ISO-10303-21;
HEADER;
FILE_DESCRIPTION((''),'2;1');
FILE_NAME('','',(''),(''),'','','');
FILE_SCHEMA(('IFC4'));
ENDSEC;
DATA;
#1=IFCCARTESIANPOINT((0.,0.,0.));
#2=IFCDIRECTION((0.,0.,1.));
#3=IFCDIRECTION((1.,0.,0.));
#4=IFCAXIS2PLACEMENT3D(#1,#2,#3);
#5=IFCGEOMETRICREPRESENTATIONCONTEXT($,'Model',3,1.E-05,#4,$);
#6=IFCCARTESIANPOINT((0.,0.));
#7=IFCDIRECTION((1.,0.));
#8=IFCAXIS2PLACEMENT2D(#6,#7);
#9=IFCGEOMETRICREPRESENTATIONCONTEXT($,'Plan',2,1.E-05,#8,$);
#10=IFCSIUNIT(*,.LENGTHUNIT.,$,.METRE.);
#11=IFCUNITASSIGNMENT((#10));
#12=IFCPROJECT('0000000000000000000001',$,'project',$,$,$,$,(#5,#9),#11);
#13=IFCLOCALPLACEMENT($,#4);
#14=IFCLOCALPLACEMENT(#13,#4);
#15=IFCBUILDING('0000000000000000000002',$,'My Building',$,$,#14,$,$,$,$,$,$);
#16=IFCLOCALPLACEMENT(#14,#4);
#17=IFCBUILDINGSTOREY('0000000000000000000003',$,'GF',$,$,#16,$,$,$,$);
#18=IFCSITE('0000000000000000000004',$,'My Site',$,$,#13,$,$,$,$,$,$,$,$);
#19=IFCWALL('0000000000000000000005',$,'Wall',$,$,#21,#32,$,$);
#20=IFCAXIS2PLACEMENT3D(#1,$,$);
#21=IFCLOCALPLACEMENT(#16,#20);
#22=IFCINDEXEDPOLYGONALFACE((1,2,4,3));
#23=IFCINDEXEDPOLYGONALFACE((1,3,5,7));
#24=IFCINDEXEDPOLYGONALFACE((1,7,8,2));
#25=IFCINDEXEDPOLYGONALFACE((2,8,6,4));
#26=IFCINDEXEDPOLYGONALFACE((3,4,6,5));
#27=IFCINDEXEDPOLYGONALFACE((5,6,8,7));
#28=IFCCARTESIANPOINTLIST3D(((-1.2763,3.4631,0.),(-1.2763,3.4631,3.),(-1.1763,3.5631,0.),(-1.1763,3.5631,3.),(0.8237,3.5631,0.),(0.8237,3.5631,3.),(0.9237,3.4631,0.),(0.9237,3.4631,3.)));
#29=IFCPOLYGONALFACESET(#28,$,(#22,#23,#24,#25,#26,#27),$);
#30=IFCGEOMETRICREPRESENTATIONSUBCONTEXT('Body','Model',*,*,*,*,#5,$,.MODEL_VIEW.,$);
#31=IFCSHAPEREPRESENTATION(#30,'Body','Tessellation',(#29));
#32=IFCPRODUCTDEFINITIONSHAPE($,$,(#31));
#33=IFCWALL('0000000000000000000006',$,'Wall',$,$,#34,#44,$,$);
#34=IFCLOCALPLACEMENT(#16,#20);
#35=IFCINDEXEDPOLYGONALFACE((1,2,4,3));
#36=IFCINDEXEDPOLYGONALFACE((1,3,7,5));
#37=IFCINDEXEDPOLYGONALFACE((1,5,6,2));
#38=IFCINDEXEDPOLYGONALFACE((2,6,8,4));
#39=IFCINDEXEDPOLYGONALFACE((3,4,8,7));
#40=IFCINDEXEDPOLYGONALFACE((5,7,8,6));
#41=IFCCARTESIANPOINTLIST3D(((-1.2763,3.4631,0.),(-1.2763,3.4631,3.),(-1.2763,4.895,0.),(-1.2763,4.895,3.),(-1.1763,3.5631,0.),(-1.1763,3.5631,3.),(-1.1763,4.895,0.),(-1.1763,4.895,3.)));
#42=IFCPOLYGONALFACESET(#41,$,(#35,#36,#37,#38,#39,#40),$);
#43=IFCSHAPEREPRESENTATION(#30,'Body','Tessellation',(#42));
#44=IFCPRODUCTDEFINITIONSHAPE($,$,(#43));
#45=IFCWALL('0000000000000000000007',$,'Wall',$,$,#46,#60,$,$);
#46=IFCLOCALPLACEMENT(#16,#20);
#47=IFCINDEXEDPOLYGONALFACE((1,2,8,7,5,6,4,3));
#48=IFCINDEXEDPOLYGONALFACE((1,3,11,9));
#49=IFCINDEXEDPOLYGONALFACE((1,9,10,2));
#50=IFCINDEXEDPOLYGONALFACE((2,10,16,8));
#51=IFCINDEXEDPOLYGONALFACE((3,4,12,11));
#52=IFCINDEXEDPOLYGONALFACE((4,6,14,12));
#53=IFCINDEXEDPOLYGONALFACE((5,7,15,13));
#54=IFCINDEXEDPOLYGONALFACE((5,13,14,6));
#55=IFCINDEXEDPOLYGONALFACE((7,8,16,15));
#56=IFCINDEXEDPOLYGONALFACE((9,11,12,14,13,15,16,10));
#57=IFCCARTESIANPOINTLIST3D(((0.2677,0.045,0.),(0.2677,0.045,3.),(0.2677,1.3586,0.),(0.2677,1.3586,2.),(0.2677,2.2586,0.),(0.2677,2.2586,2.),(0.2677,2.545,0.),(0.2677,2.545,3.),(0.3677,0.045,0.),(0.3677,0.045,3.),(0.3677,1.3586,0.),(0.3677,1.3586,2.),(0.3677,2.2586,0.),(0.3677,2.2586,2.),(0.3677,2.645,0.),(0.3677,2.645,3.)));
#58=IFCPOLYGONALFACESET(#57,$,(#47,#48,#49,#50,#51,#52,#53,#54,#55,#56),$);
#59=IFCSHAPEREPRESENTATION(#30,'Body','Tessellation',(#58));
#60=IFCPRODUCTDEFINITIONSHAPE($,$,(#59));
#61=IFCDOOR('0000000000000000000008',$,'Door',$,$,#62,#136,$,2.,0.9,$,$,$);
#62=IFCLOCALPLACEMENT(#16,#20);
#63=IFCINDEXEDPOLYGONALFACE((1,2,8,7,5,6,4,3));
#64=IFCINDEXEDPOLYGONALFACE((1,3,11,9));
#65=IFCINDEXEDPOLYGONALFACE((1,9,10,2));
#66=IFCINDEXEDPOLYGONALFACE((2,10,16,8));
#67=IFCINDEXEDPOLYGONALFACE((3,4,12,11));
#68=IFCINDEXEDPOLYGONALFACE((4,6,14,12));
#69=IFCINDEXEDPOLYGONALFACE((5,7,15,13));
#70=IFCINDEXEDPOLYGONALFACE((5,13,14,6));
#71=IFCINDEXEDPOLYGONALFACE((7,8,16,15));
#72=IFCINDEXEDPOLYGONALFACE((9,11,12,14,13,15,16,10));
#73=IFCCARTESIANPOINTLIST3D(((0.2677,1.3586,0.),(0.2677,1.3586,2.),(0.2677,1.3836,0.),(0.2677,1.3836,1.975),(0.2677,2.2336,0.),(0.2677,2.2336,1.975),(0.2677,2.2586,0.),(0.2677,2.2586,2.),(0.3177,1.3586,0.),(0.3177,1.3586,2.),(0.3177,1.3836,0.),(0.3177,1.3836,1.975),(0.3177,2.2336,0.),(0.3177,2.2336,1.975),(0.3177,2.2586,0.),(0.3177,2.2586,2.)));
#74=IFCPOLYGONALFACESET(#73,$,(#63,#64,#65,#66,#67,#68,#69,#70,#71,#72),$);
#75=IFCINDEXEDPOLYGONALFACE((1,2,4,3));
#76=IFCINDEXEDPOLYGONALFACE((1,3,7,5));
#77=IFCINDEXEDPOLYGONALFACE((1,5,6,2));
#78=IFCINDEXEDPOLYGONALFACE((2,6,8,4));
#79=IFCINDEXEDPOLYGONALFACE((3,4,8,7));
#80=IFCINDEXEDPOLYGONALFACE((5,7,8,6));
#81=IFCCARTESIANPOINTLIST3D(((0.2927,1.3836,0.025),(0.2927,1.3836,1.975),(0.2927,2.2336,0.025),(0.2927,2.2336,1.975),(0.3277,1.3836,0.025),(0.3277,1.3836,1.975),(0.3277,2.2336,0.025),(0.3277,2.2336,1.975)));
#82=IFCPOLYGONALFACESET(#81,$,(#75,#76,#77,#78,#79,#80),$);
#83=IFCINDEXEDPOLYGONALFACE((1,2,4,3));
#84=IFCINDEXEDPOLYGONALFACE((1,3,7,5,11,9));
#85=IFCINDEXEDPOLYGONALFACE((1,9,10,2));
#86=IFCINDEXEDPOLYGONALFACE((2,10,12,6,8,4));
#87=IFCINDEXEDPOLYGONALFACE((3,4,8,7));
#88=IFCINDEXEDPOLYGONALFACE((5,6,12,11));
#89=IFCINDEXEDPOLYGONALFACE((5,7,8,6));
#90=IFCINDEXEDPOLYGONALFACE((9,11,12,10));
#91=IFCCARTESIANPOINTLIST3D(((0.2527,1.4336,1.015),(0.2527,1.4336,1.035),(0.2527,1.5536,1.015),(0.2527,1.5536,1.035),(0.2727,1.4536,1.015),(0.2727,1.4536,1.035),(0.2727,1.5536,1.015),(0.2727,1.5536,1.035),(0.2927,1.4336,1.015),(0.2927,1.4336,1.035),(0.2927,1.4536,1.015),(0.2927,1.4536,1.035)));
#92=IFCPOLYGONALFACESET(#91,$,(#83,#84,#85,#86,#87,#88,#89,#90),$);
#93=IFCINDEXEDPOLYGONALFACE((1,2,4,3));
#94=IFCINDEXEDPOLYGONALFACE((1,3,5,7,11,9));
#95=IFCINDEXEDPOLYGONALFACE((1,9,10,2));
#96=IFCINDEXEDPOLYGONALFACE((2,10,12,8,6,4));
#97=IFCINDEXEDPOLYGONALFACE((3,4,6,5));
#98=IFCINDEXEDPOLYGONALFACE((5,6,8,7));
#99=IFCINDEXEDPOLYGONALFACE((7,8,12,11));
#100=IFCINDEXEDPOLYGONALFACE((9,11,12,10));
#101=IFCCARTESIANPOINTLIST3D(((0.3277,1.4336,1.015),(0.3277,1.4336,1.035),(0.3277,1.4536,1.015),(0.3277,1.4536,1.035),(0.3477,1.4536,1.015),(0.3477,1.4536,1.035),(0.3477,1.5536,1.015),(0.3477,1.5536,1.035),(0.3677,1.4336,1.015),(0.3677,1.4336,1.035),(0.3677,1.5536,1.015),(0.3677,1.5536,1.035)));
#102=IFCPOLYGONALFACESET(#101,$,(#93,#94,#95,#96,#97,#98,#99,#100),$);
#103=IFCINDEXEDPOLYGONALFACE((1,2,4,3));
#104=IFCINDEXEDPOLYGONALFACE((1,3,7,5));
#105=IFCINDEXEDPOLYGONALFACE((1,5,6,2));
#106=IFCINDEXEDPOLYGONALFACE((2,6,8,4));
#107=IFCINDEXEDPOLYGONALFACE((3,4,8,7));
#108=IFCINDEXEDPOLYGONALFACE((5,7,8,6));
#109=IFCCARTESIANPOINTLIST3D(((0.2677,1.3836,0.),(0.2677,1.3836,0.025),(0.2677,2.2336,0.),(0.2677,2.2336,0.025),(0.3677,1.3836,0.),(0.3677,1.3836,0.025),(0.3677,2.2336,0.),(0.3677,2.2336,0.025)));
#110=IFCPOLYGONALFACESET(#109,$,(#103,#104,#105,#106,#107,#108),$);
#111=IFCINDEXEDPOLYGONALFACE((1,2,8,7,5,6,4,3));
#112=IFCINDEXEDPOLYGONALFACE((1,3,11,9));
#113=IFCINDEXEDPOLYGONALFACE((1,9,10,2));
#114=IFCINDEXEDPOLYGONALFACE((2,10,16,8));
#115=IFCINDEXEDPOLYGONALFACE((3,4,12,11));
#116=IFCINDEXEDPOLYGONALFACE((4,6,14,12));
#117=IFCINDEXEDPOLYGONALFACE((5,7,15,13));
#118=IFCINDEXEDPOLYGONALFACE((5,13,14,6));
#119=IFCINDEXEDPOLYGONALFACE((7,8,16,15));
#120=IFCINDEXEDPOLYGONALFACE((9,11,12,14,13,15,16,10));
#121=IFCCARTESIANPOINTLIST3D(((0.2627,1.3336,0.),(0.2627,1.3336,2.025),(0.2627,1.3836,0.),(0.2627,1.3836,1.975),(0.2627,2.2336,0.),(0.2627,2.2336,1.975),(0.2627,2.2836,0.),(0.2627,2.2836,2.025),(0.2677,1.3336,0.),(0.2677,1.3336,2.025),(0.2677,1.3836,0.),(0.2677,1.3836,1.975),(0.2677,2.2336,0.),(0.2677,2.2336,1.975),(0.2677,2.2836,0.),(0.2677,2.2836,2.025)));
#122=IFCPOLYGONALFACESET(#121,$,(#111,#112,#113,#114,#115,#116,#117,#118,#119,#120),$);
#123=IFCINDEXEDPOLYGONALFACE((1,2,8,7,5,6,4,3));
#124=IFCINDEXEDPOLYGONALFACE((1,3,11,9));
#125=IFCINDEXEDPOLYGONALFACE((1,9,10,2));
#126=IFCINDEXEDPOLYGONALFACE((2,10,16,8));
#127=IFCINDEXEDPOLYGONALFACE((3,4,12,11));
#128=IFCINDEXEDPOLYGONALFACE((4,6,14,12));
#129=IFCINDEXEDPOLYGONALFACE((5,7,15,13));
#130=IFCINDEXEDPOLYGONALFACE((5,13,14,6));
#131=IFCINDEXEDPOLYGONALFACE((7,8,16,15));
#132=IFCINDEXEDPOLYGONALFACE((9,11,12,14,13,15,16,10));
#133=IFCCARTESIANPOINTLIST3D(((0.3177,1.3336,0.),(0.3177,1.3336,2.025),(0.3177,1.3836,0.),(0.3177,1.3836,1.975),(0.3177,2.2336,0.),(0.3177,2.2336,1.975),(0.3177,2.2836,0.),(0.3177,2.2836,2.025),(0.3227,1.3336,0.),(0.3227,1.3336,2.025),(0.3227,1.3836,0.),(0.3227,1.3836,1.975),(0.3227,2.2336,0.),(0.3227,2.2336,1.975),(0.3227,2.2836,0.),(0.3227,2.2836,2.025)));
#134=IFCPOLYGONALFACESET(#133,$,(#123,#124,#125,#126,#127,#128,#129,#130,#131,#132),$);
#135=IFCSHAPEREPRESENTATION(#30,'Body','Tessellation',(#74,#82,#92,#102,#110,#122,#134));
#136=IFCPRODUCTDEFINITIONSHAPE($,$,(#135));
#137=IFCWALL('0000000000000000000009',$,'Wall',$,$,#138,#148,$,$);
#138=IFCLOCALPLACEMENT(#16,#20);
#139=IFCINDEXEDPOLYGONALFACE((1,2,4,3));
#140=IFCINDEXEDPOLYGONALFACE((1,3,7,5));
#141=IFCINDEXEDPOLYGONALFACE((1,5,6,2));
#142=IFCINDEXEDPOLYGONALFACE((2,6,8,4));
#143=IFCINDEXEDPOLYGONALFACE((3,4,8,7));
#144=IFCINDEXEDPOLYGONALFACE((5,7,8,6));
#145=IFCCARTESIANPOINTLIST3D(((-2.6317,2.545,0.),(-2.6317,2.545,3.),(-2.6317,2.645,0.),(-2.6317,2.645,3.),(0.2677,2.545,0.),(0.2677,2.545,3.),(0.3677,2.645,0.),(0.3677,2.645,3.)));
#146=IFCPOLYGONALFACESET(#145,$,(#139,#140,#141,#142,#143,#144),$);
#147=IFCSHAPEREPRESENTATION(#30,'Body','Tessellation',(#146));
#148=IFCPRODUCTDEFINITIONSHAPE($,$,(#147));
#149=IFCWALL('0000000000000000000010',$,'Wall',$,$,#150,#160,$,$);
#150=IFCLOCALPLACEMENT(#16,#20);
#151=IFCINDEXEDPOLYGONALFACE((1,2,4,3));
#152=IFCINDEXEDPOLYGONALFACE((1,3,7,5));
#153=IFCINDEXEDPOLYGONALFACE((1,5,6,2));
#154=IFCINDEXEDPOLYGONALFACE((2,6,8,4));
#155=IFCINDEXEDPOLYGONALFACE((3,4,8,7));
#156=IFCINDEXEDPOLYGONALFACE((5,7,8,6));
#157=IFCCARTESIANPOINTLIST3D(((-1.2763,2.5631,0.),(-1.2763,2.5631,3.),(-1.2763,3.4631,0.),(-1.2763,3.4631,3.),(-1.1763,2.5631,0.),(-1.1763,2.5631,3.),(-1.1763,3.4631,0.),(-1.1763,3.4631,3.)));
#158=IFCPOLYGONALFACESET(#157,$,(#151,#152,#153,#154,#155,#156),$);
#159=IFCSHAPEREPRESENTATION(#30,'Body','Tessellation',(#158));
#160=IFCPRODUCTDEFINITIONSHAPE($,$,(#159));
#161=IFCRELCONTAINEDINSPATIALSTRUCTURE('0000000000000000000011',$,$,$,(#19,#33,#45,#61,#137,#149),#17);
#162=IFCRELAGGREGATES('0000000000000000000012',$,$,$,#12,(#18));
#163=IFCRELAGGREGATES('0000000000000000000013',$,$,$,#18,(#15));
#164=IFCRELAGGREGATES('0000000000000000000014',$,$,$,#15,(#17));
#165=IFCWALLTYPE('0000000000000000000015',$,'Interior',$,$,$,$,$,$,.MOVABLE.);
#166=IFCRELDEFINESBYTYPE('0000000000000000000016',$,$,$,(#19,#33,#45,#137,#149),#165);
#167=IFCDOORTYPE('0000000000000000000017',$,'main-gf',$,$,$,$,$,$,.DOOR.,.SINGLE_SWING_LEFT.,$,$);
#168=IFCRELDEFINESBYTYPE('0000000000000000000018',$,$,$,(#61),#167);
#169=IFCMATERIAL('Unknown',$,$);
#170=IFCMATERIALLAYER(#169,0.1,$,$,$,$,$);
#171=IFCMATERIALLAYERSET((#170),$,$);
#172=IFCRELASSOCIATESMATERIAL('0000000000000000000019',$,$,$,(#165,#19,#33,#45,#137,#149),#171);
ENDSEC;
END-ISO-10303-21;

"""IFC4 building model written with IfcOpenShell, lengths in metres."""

from ifc_helpers import new_model, entity, si_unit, frame, origin_with_axes, origin_2d_with_axis, place, context, subcontext, project, spatial, line, indexed_curve, outline, extrude, shape, source, transform, mapped, material, layer, layer_set, layer_usage, type_object, type_shapes, element, fill, save


model = new_model("IFC4")

# Units and contexts
model_context = context("Model", 3, precision=1e-05, world=origin_with_axes())
plan_context = context("Plan", 2, precision=1e-05, world=origin_2d_with_axis())
body_context_1 = subcontext(model_context, "Body", "Model", "MODEL_VIEW")
body_context_2 = subcontext(plan_context, "Body", "Plan", "PLAN_VIEW")
ifc_project = project(units=[si_unit("LENGTHUNIT", "METRE")], contexts=[model_context, plan_context])

# Site, building, storey
site_placement = place(None, origin_with_axes())
site = spatial("IfcSite", under=ifc_project, at=site_placement, Name="My Site")
building_placement = place(site_placement, origin_with_axes())
building = spatial("IfcBuilding", under=site, at=building_placement, Name="My Building")
storey_placement = place(building_placement, origin_with_axes())
storey = spatial("IfcBuildingStorey", under=building, at=storey_placement, Name="GF")

# Shared definitions
ifc_material = material(Name="Unknown")
shared_shape_1 = source(origin_with_axes(), body_context_1, "Body", "SweptSolid", [
    extrude(outline(indexed_curve([(0.0, 0.0), (0.9, 0.0), (0.9, 2.0), (0.0, 2.0)], segments=[line(1, 2, 3, 4, 1)])), frame((0.0, -0.6, 0.0), z_axis=(0.0, -1.0, 0.0), x_axis=(1.0, 0.0, 0.0)), (0.0, 0.0, -1.0), 1.2),
])
door_type = type_object("IfcDoorType", Name="main-gf", OperationType="SINGLE_SWING_LEFT", PredefinedType="DOOR")
shared_shape_2 = source(origin_with_axes(), body_context_1, "Body", "SweptSolid", [
    extrude(outline(indexed_curve([(0.0, 0.0), (0.0, 2.0), (0.9, 2.0), (0.9, 0.0), (0.875, 0.0), (0.875, 1.975), (0.025, 1.975), (0.025, 0.0)], segments=[line(1, 2, 3, 4, 5, 6, 7, 8, 1)])), frame((0.0, 0.0, 0.0), z_axis=(0.0, -1.0, 0.0), x_axis=(1.0, 0.0, 0.0)), (0.0, 0.0, -1.0), 0.05),
    extrude(outline(indexed_curve([(0.0, 0.0), (0.85, 0.0), (0.85, 0.035), (0.0, 0.035)], segments=[line(1, 2, 3, 4, 1)])), frame((0.025, 0.025, 0.025), z_axis=(0.0, 0.0, 1.0), x_axis=(1.0, 0.0, 0.0)), (0.0, 0.0, 1.0), 1.95),
    extrude(outline(indexed_curve([(0.0, 0.0), (0.0, -0.04), (-0.12, -0.04), (-0.12, -0.02), (-0.02, -0.02), (-0.02, 0.0)], segments=[line(1, 2, 3, 4, 5, 6, 1)])), frame((0.825, 0.025, 1.015), z_axis=(0.0, 0.0, 1.0), x_axis=(1.0, 0.0, 0.0)), (0.0, 0.0, 1.0), 0.02),
    extrude(outline(indexed_curve([(0.0, 0.0), (0.0, 0.04), (-0.12, 0.04), (-0.12, 0.02), (-0.02, 0.02), (-0.02, 0.0)], segments=[line(1, 2, 3, 4, 5, 6, 1)])), frame((0.825, 0.06, 1.015), z_axis=(0.0, 0.0, 1.0), x_axis=(1.0, 0.0, 0.0)), (0.0, 0.0, 1.0), 0.02),
    extrude(outline(indexed_curve([(0.0, 0.0), (0.85, 0.0), (0.85, 0.1), (0.0, 0.1)], segments=[line(1, 2, 3, 4, 1)])), frame((0.025, 0.0, 0.0), z_axis=(0.0, 0.0, 1.0), x_axis=(1.0, 0.0, 0.0)), (0.0, 0.0, 1.0), 0.025),
    extrude(outline(indexed_curve([(0.0, 0.0), (0.0, 2.025), (0.95, 2.025), (0.95, 0.0), (0.9, 0.0), (0.9, 1.975), (0.05, 1.975), (0.05, 0.0)], segments=[line(1, 2, 3, 4, 5, 6, 7, 8, 1)])), frame((-0.025, -0.005, 0.0), z_axis=(0.0, -1.0, 0.0), x_axis=(1.0, 0.0, 0.0)), (0.0, 0.0, -1.0), 0.005),
    extrude(outline(indexed_curve([(0.0, 0.0), (0.0, 2.025), (0.95, 2.025), (0.95, 0.0), (0.9, 0.0), (0.9, 1.975), (0.05, 1.975), (0.05, 0.0)], segments=[line(1, 2, 3, 4, 5, 6, 7, 8, 1)])), frame((-0.025, 0.05, 0.0), z_axis=(0.0, -1.0, 0.0), x_axis=(1.0, 0.0, 0.0)), (0.0, 0.0, -1.0), 0.005),
])
shared_shape_3 = source(origin_with_axes(), body_context_2, "Body", "Curve2D", [
    entity("IfcIndexedPolyCurve", entity("IfcCartesianPointList2D", [[0.0, 0.0], [0.025, 0.0], [0.025, 0.05], [0.0, 0.05]]), [entity("IfcLineIndex", [1, 2, 3, 4, 1])]),
    entity("IfcIndexedPolyCurve", entity("IfcCartesianPointList2D", [[0.9, 0.0], [0.875, 0.0], [0.875, 0.05], [0.9, 0.05]]), [entity("IfcLineIndex", [1, 2, 3, 4, 1])]),
    entity("IfcIndexedPolyCurve", entity("IfcCartesianPointList2D", [[0.025, 0.05], [0.025, -0.8], [0.06, -0.8]])),
    entity("IfcTrimmedCurve", entity("IfcEllipse", entity("IfcAxis2Placement2D", entity("IfcCartesianPoint", [0.06, 0.05]), entity("IfcDirection", [1.0, 0.0])), 0.815, 0.85), [entity("IfcCartesianPoint", [0.06, -0.8])], [entity("IfcCartesianPoint", [0.06, 0.9])], True, "CARTESIAN"),
    entity("IfcIndexedPolyCurve", entity("IfcCartesianPointList2D", [[0.025, 0.05], [0.06, 0.05], [0.06, 0.9], [0.025, 0.9]]), [entity("IfcLineIndex", [1, 2, 3, 4, 1])]),
])
type_shapes(door_type, [shared_shape_2, shared_shape_3])

# Walls
ifc_layer_1 = layer(ifc_material, 0.1)
ifc_layer_set_1 = layer_set([ifc_layer_1])
wall_type_1 = type_object("IfcWallType", Name="Interior", PredefinedType="MOVABLE", material=ifc_layer_set_1)
ifc_layer_usage_1 = layer_usage(ifc_layer_set_1, "AXIS2", "POSITIVE", 0.0)
wall_1_placement = place(storey_placement, frame((0.8237, 3.5631, 0.0), z_axis=(0.0, 0.0, 1.0), x_axis=(-1.0, 0.0, 0.0)))
element("IfcWall", 1, at=wall_1_placement, inside=storey, type_object=wall_type_1, material=ifc_layer_usage_1, Name="Wall", context=body_context_1, shape_type="SweptSolid", body=[
    extrude(outline(indexed_curve([(0.0, 0.0), (-0.1, 0.1), (2.1, 0.1), (2.0, 0.0)], segments=[line(1, 2, 3, 4, 1)])), origin_with_axes(), (0.0, 0.0, 1.0), 3.0),
])
ifc_layer_usage_2 = layer_usage(ifc_layer_set_1, "AXIS2", "POSITIVE", 0.0)
wall_2_placement = place(storey_placement, frame((-1.1763, 3.5631, 0.0), z_axis=(0.0, 0.0, 1.0), x_axis=(0.0, 1.0, 0.0)))
element("IfcWall", 2, at=wall_2_placement, inside=storey, type_object=wall_type_1, material=ifc_layer_usage_2, Name="Wall", context=body_context_1, shape_type="SweptSolid", body=[
    extrude(outline(indexed_curve([(0.0, 0.0), (-0.1, 0.1), (1.3318, 0.1), (1.3318, 0.0)], segments=[line(1, 2, 3, 4, 1)])), origin_with_axes(), (0.0, 0.0, 1.0), 3.0),
])

# Wall, opening, door
ifc_layer_usage_3 = layer_usage(ifc_layer_set_1, "AXIS2", "POSITIVE", 0.0)
wall_3_placement = place(storey_placement, frame((0.3677, 0.045, 0.0), z_axis=(0.0, 0.0, 1.0), x_axis=(0.0, 1.0, 0.0)))
wall_3 = element("IfcWall", 3, at=wall_3_placement, inside=storey, type_object=wall_type_1, material=ifc_layer_usage_3, Name="Wall", context=body_context_1, shape_type="SweptSolid", body=[
    extrude(outline(indexed_curve([(0.0, 0.0), (0.0, 0.1), (2.5, 0.1), (2.6, 0.0)], segments=[line(1, 2, 3, 4, 1)])), origin_with_axes(), (0.0, 0.0, 1.0), 3.0),
])
opening_1_placement = place(wall_3_placement, frame((2.2136, 0.1, 0.0), z_axis=(0.0, 0.0, 1.0), x_axis=(-1.0, 0.0, 0.0)))
opening_1 = element("IfcOpeningElement", 4, at=opening_1_placement, cuts=wall_3, PredefinedType="OPENING", context=body_context_1, shape_type="MappedRepresentation", body=[
    mapped(shared_shape_1, transform((0.0, 0.0, 0.0), x_axis=(1.0, 0.0, 0.0), y_axis=(0.0, 1.0, 0.0), z_axis=(0.0, 0.0, 1.0), scale=1.0)),
])
door_1_placement = place(opening_1_placement, frame((0.0, 0.0, 0.0), z_axis=(0.0, 0.0, 1.0), x_axis=(1.0, 0.0, 0.0)))
door_1 = element("IfcDoor", 5, at=door_1_placement, inside=storey, type_object=door_type, Name="Door", OverallHeight=2.0, OverallWidth=0.9, shapes=[
    shape(body_context_1, "Body", "MappedRepresentation", [mapped(shared_shape_2, transform((0.0, 0.0, 0.0), x_axis=(1.0, 0.0, 0.0), y_axis=(0.0, 1.0, 0.0), z_axis=(0.0, 0.0, 1.0), scale=1.0))]),
    shape(body_context_2, "Body", "MappedRepresentation", [mapped(shared_shape_3, transform((0.0, 0.0, 0.0), x_axis=(1.0, 0.0, 0.0), y_axis=(0.0, 1.0, 0.0), z_axis=(0.0, 0.0, 1.0), scale=1.0))]),
])
fill(opening_1, door_1)

# Walls
ifc_layer_usage_4 = layer_usage(ifc_layer_set_1, "AXIS2", "POSITIVE", 0.0)
wall_4_placement = place(storey_placement, frame((0.3677, 2.645, 0.0), z_axis=(0.0, 0.0, 1.0), x_axis=(-1.0, 0.0, 0.0)))
element("IfcWall", 6, at=wall_4_placement, inside=storey, type_object=wall_type_1, material=ifc_layer_usage_4, Name="Wall", context=body_context_1, shape_type="SweptSolid", body=[
    extrude(outline(indexed_curve([(0.0, 0.0), (0.1, 0.1), (2.9994, 0.1), (2.9994, 0.0)], segments=[line(1, 2, 3, 4, 1)])), origin_with_axes(), (0.0, 0.0, 1.0), 3.0),
])
ifc_layer_usage_5 = layer_usage(ifc_layer_set_1, "AXIS2", "POSITIVE", 0.0)
wall_5_placement = place(storey_placement, frame((-1.2763, 3.4631, 0.0), z_axis=(0.0, 0.0, 1.0), x_axis=(0.0, -1.0, 0.0)))
element("IfcWall", 7, at=wall_5_placement, inside=storey, type_object=wall_type_1, material=ifc_layer_usage_5, Name="Wall", context=body_context_1, shape_type="SweptSolid", body=[
    extrude(outline(indexed_curve([(0.0, 0.0), (0.0, 0.1), (0.9, 0.1), (0.9, 0.0)], segments=[line(1, 2, 3, 4, 1)])), origin_with_axes(), (0.0, 0.0, 1.0), 3.0),
])

save(model, "model.ifc")
